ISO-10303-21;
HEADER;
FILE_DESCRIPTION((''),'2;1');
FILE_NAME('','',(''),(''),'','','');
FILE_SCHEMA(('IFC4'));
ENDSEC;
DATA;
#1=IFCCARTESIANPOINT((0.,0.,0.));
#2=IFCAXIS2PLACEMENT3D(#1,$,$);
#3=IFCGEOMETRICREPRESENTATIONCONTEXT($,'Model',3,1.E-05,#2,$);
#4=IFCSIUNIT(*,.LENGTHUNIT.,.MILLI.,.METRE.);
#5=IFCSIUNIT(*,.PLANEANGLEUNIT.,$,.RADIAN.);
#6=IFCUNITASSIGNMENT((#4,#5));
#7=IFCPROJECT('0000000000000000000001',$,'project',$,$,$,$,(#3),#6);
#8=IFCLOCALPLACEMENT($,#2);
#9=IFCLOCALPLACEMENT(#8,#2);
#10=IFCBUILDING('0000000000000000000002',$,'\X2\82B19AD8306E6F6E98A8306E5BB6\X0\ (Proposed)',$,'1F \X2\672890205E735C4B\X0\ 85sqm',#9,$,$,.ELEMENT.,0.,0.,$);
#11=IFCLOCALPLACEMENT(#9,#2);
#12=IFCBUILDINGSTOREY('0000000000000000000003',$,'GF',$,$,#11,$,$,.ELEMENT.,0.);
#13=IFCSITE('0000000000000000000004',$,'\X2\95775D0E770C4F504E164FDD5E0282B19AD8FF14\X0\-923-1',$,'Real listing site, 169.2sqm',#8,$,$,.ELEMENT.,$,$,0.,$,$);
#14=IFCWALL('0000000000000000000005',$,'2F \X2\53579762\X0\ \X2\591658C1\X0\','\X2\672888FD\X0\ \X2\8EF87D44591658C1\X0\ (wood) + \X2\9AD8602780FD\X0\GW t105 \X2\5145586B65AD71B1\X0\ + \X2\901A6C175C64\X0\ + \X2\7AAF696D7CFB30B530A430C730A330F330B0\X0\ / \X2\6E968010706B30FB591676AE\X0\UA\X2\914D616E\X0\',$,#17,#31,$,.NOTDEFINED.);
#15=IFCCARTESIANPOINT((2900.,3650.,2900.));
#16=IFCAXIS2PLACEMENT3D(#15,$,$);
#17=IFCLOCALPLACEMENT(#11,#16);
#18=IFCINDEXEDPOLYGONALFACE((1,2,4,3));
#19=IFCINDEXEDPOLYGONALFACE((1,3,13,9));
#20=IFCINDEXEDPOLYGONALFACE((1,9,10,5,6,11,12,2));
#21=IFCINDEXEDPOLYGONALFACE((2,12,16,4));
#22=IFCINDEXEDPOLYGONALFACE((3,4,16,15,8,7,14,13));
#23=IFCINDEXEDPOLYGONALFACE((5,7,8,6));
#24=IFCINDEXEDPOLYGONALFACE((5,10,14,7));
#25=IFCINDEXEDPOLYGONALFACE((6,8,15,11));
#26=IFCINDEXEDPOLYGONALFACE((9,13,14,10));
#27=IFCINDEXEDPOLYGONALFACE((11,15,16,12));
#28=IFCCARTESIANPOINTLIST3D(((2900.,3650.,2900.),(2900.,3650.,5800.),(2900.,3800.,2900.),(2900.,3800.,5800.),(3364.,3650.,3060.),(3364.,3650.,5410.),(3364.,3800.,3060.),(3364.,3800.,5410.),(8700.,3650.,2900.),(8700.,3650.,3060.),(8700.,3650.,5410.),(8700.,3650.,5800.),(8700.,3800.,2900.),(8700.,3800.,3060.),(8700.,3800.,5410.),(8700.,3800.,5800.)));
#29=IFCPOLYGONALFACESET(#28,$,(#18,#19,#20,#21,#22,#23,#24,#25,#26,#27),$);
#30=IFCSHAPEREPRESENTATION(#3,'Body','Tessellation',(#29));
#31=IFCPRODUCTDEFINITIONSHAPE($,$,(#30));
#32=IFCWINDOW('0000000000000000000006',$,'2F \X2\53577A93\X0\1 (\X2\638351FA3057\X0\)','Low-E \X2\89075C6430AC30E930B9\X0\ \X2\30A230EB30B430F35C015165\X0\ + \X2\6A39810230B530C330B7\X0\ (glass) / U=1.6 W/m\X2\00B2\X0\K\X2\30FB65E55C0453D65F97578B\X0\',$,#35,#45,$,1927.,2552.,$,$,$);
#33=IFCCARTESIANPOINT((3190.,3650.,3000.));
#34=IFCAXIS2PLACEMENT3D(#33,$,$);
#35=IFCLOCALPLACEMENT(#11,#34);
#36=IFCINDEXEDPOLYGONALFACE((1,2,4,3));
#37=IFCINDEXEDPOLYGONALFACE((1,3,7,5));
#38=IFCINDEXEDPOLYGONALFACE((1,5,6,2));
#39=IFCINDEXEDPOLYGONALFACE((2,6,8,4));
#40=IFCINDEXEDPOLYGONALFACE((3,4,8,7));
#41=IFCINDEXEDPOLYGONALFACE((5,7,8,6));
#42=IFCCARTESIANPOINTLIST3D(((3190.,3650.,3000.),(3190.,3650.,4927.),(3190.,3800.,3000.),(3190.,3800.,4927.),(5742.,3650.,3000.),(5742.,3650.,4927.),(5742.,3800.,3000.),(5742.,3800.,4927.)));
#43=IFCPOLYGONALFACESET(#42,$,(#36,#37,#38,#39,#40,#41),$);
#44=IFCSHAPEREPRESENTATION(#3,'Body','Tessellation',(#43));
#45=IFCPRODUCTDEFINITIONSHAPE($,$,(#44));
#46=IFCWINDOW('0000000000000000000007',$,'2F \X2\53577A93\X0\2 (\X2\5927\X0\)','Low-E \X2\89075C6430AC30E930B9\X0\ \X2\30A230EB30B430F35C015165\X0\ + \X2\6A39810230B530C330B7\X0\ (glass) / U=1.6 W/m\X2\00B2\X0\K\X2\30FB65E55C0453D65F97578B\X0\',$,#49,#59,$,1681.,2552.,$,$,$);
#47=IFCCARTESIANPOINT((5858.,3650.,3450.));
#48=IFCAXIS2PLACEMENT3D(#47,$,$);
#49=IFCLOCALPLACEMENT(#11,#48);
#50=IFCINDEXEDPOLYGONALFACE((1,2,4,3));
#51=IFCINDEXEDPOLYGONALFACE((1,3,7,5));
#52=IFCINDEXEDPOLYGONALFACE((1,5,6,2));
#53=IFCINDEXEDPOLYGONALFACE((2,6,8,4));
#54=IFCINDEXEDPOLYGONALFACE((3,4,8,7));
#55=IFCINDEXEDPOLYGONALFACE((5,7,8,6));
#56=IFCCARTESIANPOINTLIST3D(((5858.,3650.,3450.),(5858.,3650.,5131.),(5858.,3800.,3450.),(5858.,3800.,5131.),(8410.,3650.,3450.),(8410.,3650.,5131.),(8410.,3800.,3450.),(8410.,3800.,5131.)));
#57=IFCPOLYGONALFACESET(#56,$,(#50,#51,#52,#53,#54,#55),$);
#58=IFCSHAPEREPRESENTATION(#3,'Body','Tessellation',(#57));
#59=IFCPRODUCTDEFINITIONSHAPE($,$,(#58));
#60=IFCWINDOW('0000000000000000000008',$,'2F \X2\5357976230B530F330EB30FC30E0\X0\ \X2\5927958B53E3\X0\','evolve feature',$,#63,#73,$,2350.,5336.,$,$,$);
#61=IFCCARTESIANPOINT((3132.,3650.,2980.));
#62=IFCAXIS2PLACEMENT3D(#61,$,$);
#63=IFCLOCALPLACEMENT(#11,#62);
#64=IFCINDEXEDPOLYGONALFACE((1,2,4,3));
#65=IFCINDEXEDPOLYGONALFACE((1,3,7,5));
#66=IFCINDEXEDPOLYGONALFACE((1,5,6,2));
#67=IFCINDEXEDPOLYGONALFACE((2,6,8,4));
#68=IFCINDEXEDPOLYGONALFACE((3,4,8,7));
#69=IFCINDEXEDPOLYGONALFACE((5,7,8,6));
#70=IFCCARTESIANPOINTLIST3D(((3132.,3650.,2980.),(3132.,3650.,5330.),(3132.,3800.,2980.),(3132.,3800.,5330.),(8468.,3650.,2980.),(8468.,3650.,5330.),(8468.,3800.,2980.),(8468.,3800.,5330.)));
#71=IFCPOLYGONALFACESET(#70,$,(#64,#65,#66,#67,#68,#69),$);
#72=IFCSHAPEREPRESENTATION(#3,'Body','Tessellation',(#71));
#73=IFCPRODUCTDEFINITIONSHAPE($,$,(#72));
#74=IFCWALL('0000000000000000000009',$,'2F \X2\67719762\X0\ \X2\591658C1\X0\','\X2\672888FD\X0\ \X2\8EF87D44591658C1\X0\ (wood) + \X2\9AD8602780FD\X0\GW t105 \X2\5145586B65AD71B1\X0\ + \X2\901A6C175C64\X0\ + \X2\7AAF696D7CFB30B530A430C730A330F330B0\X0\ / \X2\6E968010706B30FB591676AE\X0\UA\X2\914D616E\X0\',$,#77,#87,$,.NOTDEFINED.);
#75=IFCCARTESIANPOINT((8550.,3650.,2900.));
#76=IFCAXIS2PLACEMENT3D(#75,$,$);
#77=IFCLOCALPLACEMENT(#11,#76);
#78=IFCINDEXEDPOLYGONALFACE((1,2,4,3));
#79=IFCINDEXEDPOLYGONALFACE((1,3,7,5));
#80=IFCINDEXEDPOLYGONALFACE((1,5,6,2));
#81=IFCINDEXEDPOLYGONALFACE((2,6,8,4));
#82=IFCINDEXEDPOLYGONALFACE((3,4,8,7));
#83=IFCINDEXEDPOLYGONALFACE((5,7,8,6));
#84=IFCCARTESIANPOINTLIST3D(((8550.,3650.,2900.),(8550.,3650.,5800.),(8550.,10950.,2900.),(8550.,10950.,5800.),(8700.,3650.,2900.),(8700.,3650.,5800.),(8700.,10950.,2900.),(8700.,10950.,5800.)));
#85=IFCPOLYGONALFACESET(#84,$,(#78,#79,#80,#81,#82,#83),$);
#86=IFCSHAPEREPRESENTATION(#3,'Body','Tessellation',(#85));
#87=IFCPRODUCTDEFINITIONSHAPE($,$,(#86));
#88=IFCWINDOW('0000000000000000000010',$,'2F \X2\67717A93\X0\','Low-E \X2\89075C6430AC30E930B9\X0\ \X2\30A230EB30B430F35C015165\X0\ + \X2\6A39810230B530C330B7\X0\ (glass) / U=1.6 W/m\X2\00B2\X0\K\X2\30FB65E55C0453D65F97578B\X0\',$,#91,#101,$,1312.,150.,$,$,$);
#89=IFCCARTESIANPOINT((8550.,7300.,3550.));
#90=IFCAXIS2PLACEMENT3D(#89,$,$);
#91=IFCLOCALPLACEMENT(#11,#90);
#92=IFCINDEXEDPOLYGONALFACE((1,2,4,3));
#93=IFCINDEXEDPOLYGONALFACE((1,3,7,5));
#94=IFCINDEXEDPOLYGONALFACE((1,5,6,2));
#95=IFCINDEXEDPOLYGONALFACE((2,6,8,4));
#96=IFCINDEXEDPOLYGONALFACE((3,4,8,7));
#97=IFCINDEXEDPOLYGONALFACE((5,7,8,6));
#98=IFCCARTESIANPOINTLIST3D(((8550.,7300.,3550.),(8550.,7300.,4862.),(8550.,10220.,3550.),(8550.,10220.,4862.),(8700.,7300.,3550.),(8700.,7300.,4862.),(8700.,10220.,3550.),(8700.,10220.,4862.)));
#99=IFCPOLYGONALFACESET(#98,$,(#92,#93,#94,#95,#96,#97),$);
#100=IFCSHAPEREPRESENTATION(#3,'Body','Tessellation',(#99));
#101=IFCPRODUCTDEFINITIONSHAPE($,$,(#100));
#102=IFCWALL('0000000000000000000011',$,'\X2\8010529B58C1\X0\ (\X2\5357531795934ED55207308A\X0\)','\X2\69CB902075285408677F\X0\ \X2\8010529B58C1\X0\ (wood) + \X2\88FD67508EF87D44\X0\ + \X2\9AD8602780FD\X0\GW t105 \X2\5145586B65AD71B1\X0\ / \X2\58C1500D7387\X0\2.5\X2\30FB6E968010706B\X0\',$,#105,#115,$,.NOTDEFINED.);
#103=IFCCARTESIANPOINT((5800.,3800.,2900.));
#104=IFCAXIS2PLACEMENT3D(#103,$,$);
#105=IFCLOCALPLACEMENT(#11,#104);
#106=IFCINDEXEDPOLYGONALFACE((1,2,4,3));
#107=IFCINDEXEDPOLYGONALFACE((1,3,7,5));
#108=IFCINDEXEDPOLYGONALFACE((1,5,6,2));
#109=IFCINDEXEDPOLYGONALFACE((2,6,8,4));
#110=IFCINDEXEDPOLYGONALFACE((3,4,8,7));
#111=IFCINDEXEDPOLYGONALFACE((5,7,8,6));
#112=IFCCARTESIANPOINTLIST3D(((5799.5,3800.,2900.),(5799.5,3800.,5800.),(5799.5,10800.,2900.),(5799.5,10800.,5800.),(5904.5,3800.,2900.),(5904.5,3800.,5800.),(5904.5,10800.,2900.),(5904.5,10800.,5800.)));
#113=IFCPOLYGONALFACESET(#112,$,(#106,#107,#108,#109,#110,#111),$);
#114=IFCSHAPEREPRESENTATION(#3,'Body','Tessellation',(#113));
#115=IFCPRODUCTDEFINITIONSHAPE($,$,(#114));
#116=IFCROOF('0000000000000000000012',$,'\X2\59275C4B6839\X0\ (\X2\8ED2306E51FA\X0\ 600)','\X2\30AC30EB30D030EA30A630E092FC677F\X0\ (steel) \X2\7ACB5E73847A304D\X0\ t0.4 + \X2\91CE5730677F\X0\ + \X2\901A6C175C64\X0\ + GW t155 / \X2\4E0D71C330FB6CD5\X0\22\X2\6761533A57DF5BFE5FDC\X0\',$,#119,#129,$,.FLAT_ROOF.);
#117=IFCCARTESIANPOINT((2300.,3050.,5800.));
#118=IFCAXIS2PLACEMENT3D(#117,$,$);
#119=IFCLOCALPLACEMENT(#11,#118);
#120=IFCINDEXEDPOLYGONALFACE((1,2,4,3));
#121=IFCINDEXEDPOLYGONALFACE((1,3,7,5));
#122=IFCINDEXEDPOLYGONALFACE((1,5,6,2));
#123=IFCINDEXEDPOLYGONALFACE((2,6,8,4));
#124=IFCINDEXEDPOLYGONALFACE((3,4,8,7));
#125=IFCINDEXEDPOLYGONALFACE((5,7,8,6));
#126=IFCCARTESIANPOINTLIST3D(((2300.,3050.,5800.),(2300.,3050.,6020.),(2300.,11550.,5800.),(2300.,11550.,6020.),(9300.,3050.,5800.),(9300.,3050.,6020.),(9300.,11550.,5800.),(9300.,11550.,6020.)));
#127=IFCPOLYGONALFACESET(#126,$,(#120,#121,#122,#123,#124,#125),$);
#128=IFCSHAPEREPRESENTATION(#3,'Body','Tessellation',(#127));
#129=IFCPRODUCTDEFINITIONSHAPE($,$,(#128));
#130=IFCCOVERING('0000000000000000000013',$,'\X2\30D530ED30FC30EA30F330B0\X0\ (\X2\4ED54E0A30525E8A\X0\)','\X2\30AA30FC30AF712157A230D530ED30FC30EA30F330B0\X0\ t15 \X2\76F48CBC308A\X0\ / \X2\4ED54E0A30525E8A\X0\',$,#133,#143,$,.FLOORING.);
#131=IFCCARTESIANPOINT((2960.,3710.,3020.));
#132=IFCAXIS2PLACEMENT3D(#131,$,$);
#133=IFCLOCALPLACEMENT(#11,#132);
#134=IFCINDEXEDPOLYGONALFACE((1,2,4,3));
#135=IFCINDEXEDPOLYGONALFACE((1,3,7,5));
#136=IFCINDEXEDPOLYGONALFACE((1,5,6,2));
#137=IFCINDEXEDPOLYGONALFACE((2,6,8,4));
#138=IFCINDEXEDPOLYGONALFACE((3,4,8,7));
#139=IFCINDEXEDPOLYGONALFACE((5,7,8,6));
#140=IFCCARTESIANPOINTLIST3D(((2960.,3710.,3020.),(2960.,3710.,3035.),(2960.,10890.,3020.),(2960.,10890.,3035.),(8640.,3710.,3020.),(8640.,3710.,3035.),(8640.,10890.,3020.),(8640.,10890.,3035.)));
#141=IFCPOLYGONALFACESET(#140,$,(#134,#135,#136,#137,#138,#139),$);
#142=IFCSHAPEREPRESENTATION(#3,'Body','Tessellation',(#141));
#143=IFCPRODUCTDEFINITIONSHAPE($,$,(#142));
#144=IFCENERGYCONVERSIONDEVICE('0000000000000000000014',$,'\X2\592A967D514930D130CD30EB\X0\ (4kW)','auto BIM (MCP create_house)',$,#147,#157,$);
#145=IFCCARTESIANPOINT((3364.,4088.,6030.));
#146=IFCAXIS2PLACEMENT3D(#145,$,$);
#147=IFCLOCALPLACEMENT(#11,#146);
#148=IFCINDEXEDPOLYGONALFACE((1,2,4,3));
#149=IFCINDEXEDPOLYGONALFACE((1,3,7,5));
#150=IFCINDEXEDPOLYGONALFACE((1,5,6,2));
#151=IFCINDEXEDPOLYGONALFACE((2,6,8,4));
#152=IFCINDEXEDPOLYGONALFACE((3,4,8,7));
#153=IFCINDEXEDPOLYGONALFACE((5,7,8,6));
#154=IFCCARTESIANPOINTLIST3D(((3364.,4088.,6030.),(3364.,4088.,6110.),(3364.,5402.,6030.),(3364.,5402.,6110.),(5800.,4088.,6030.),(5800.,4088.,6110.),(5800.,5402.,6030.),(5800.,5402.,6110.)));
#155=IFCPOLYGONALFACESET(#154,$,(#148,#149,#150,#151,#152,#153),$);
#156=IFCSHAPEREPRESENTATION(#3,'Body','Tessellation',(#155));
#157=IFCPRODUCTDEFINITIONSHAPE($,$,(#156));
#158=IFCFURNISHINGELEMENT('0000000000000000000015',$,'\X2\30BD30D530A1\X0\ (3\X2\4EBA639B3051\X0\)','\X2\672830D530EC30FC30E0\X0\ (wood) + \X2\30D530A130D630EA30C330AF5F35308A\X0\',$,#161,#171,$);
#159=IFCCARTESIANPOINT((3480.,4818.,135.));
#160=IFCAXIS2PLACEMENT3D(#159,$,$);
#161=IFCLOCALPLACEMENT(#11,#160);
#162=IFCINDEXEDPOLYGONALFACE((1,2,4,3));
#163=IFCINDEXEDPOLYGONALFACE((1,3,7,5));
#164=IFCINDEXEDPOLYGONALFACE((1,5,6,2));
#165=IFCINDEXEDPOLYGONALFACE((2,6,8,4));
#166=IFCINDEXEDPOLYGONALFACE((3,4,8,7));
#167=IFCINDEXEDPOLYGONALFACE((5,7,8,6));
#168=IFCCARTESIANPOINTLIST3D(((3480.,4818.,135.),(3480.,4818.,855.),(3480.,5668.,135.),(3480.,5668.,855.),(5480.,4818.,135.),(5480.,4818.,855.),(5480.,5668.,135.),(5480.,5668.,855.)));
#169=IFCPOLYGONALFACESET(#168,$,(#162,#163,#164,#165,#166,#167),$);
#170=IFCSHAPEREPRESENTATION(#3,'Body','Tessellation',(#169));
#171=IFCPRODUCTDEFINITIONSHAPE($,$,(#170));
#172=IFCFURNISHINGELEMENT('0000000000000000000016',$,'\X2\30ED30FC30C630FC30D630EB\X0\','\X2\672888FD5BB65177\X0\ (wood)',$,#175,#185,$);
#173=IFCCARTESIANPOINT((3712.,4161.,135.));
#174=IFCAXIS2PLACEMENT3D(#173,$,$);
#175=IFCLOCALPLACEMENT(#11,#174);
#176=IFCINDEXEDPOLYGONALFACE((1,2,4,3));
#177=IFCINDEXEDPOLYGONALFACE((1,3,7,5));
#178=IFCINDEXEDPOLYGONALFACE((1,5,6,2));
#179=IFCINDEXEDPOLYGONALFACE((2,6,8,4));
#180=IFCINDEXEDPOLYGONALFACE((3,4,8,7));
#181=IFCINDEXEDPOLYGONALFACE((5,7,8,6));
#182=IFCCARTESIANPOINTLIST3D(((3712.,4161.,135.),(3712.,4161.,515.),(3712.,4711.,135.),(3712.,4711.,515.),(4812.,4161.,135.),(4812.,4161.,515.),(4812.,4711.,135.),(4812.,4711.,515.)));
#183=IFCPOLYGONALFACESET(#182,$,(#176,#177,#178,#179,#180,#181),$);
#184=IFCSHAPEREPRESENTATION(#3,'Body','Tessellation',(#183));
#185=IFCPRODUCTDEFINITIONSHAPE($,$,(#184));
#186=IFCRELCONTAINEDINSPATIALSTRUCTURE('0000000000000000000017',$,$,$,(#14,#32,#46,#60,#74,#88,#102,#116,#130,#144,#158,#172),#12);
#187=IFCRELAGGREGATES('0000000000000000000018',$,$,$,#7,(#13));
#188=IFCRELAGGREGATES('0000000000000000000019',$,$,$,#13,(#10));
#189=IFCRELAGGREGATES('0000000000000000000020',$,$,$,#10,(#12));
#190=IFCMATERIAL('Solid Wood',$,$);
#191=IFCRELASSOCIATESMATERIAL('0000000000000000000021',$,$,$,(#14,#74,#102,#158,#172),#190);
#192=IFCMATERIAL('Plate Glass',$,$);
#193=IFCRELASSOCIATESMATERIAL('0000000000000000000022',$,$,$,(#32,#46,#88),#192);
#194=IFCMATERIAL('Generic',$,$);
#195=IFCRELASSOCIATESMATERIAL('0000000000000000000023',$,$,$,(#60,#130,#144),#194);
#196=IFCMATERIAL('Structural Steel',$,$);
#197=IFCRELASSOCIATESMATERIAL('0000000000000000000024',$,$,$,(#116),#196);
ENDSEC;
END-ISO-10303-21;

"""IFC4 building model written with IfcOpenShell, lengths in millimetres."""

from ifc_helpers import new_model, si_unit, frame, frame_2d, origin, place, context, project, spatial, rectangle, extrude, material, element, fill, save


model = new_model("IFC4")

# Units and contexts
model_context = context("Model", 3, precision=1e-05, world=origin())
ifc_project = project(units=[si_unit("LENGTHUNIT", "METRE", prefix="MILLI"), si_unit("PLANEANGLEUNIT", "RADIAN")], contexts=[model_context])

# Site, building, storey
site_placement = place(None, origin())
site = spatial("IfcSite", under=ifc_project, at=site_placement, Name="長崎県佐世保市花高４-923-1", ObjectType="Real listing site, 169.2sqm", CompositionType="ELEMENT", RefElevation=0.0)
building_placement = place(site_placement, origin())
building = spatial("IfcBuilding", under=site, at=building_placement, Name="花高の潮風の家 (Proposed)", ObjectType="1F 木造平屋 85sqm", CompositionType="ELEMENT", ElevationOfRefHeight=0.0, ElevationOfTerrain=0.0)
storey_placement = place(building_placement, origin())
storey = spatial("IfcBuildingStorey", under=building, at=storey_placement, Name="GF", CompositionType="ELEMENT", Elevation=0.0)

# Shared definitions
ifc_material_1 = material(Name="Solid Wood")

# Wall, openings, windows
wall_1_placement = place(storey_placement, frame((2900.0, 3650.0, 2900.0)))
wall_1 = element("IfcWall", 1, at=wall_1_placement, inside=storey, material=ifc_material_1, Name="2F 南面 外壁", Description="木製 軸組外壁 (wood) + 高性能GW t105 充填断熱 + 通気層 + 窯業系サイディング / 準耐火・外皮UA配慮", PredefinedType="NOTDEFINED", context=model_context, shape_type="SweptSolid", body=[
    extrude(rectangle(XDim=5800.0, YDim=150.0, at=frame_2d((2900.0, 75.0))), frame((2900.0, 3650.0, 2900.0)), (0.0, 0.0, 1.0), 2900.0),
])
opening_1_placement = place(storey_placement, frame((3190.0, 3650.0, 3000.0)))
opening_1 = element("IfcOpeningElement", 2, at=opening_1_placement, cuts=wall_1, PredefinedType="NOTDEFINED", context=model_context, shape_type="SweptSolid", body=[
    extrude(rectangle(XDim=2552.0, YDim=150.0, at=frame_2d((1276.0, 75.0))), frame((3190.0, 3650.0, 3000.0)), (0.0, 0.0, 1.0), 1927.0),
])
opening_2_placement = place(storey_placement, frame((5858.0, 3650.0, 3450.0)))
opening_2 = element("IfcOpeningElement", 3, at=opening_2_placement, cuts=wall_1, PredefinedType="NOTDEFINED", context=model_context, shape_type="SweptSolid", body=[
    extrude(rectangle(XDim=2552.0, YDim=150.0, at=frame_2d((1276.0, 75.0))), frame((5858.0, 3650.0, 3450.0)), (0.0, 0.0, 1.0), 1681.0),
])
opening_3_placement = place(storey_placement, frame((3132.0, 3650.0, 2980.0)))
opening_3 = element("IfcOpeningElement", 4, at=opening_3_placement, cuts=wall_1, PredefinedType="NOTDEFINED", context=model_context, shape_type="SweptSolid", body=[
    extrude(rectangle(XDim=5336.0, YDim=150.0, at=frame_2d((2668.0, 75.0))), frame((3132.0, 3650.0, 2980.0)), (0.0, 0.0, 1.0), 2350.0),
])
ifc_material_2 = material(Name="Plate Glass")
window_1_placement = place(storey_placement, frame((3190.0, 3650.0, 3000.0)))
window_1 = element("IfcWindow", 5, at=window_1_placement, inside=storey, material=ifc_material_2, Name="2F 南窓1 (掃出し)", Description="Low-E 複層ガラス アルゴン封入 + 樹脂サッシ (glass) / U=1.6 W/m²K・日射取得型", OverallHeight=1927.0, OverallWidth=2552.0, context=model_context, shape_type="SweptSolid", body=[
    extrude(rectangle(XDim=2552.0, YDim=150.0, at=frame_2d((1276.0, 75.0))), frame((3190.0, 3650.0, 3000.0)), (0.0, 0.0, 1.0), 1927.0),
])
fill(opening_1, window_1)
window_2_placement = place(storey_placement, frame((5858.0, 3650.0, 3450.0)))
window_2 = element("IfcWindow", 6, at=window_2_placement, inside=storey, material=ifc_material_2, Name="2F 南窓2 (大)", Description="Low-E 複層ガラス アルゴン封入 + 樹脂サッシ (glass) / U=1.6 W/m²K・日射取得型", OverallHeight=1681.0, OverallWidth=2552.0, context=model_context, shape_type="SweptSolid", body=[
    extrude(rectangle(XDim=2552.0, YDim=150.0, at=frame_2d((1276.0, 75.0))), frame((5858.0, 3650.0, 3450.0)), (0.0, 0.0, 1.0), 1681.0),
])
fill(opening_2, window_2)
ifc_material_3 = material(Name="Generic")
window_3_placement = place(storey_placement, frame((3132.0, 3650.0, 2980.0)))
window_3 = element("IfcWindow", 7, at=window_3_placement, inside=storey, material=ifc_material_3, Name="2F 南面サンルーム 大開口", Description="evolve feature", OverallHeight=2350.0, OverallWidth=5336.0, context=model_context, shape_type="SweptSolid", body=[
    extrude(rectangle(XDim=5336.0, YDim=150.0, at=frame_2d((2668.0, 75.0))), frame((3132.0, 3650.0, 2980.0)), (0.0, 0.0, 1.0), 2350.0),
])
fill(opening_3, window_3)

# Wall, opening, window
wall_2_placement = place(storey_placement, frame((8550.0, 3650.0, 2900.0)))
wall_2 = element("IfcWall", 8, at=wall_2_placement, inside=storey, material=ifc_material_1, Name="2F 東面 外壁", Description="木製 軸組外壁 (wood) + 高性能GW t105 充填断熱 + 通気層 + 窯業系サイディング / 準耐火・外皮UA配慮", PredefinedType="NOTDEFINED", context=model_context, shape_type="SweptSolid", body=[
    extrude(rectangle(XDim=150.0, YDim=7300.0, at=frame_2d((75.0, 3650.0))), frame((8550.0, 3650.0, 2900.0)), (0.0, 0.0, 1.0), 2900.0),
])
opening_4_placement = place(storey_placement, frame((8550.0, 7300.0, 3550.0)))
opening_4 = element("IfcOpeningElement", 9, at=opening_4_placement, cuts=wall_2, PredefinedType="NOTDEFINED", context=model_context, shape_type="SweptSolid", body=[
    extrude(rectangle(XDim=150.0, YDim=2920.0, at=frame_2d((75.0, 1460.0))), frame((8550.0, 7300.0, 3550.0)), (0.0, 0.0, 1.0), 1312.0),
])
window_4_placement = place(storey_placement, frame((8550.0, 7300.0, 3550.0)))
window_4 = element("IfcWindow", 10, at=window_4_placement, inside=storey, material=ifc_material_2, Name="2F 東窓", Description="Low-E 複層ガラス アルゴン封入 + 樹脂サッシ (glass) / U=1.6 W/m²K・日射取得型", OverallHeight=1312.0, OverallWidth=150.0, context=model_context, shape_type="SweptSolid", body=[
    extrude(rectangle(XDim=150.0, YDim=2920.0, at=frame_2d((75.0, 1460.0))), frame((8550.0, 7300.0, 3550.0)), (0.0, 0.0, 1.0), 1312.0),
])
fill(opening_4, window_4)

# Wall
wall_3_placement = place(storey_placement, frame((5800.0, 3800.0, 2900.0)))
element("IfcWall", 11, at=wall_3_placement, inside=storey, material=ifc_material_1, Name="耐力壁 (南北間仕切り)", Description="構造用合板 耐力壁 (wood) + 製材軸組 + 高性能GW t105 充填断熱 / 壁倍率2.5・準耐火", PredefinedType="NOTDEFINED", context=model_context, shape_type="SweptSolid", body=[
    extrude(rectangle(XDim=105.0, YDim=7000.0, at=frame_2d((52.0, 3500.0))), frame((5800.0, 3800.0, 2900.0)), (0.0, 0.0, 1.0), 2900.0),
])

# Roof
ifc_material_4 = material(Name="Structural Steel")
roof_placement = place(storey_placement, frame((2300.0, 3050.0, 5800.0)))
element("IfcRoof", 12, at=roof_placement, inside=storey, material=ifc_material_4, Name="大屋根 (軒の出 600)", Description="ガルバリウム鋼板 (steel) 立平葺き t0.4 + 野地板 + 通気層 + GW t155 / 不燃・法22条区域対応", PredefinedType="FLAT_ROOF", context=model_context, shape_type="SweptSolid", body=[
    extrude(rectangle(XDim=7000.0, YDim=8500.0, at=frame_2d((3500.0, 4250.0))), frame((2300.0, 3050.0, 5800.0)), (0.0, 0.0, 1.0), 220.0),
])

# Covering
covering_placement = place(storey_placement, frame((2960.0, 3710.0, 3020.0)))
element("IfcCovering", 13, at=covering_placement, inside=storey, material=ifc_material_3, Name="フローリング (仕上げ床)", Description="オーク無垢フローリング t15 直貼り / 仕上げ床", PredefinedType="FLOORING", context=model_context, shape_type="SweptSolid", body=[
    extrude(rectangle(XDim=5680.0, YDim=7180.0, at=frame_2d((2840.0, 3590.0))), frame((2960.0, 3710.0, 3020.0)), (0.0, 0.0, 1.0), 15.0),
])

# Energy conversion device
energy_conversion_device_placement = place(storey_placement, frame((3364.0, 4088.0, 6030.0)))
element("IfcEnergyConversionDevice", 14, at=energy_conversion_device_placement, inside=storey, material=ifc_material_3, Name="太陽光パネル (4kW)", Description="auto BIM (MCP create_house)", context=model_context, shape_type="SweptSolid", body=[
    extrude(rectangle(XDim=2436.0, YDim=1314.0, at=frame_2d((1218.0, 657.0))), frame((3364.0, 4088.0, 6030.0)), (0.0, 0.0, 1.0), 80.0),
])

# Furnishing elements
furnishing_1_placement = place(storey_placement, frame((3480.0, 4818.0, 135.0)))
element("IfcFurnishingElement", 15, at=furnishing_1_placement, inside=storey, material=ifc_material_1, Name="ソファ (3人掛け)", Description="木フレーム (wood) + ファブリック張り", context=model_context, shape_type="SweptSolid", body=[
    extrude(rectangle(XDim=2000.0, YDim=850.0, at=frame_2d((1000.0, 425.0))), frame((3480.0, 4818.0, 135.0)), (0.0, 0.0, 1.0), 720.0),
])
furnishing_2_placement = place(storey_placement, frame((3712.0, 4161.0, 135.0)))
element("IfcFurnishingElement", 16, at=furnishing_2_placement, inside=storey, material=ifc_material_1, Name="ローテーブル", Description="木製家具 (wood)", context=model_context, shape_type="SweptSolid", body=[
    extrude(rectangle(XDim=1100.0, YDim=550.0, at=frame_2d((550.0, 275.0))), frame((3712.0, 4161.0, 135.0)), (0.0, 0.0, 1.0), 380.0),
])

save(model, "model.ifc")
